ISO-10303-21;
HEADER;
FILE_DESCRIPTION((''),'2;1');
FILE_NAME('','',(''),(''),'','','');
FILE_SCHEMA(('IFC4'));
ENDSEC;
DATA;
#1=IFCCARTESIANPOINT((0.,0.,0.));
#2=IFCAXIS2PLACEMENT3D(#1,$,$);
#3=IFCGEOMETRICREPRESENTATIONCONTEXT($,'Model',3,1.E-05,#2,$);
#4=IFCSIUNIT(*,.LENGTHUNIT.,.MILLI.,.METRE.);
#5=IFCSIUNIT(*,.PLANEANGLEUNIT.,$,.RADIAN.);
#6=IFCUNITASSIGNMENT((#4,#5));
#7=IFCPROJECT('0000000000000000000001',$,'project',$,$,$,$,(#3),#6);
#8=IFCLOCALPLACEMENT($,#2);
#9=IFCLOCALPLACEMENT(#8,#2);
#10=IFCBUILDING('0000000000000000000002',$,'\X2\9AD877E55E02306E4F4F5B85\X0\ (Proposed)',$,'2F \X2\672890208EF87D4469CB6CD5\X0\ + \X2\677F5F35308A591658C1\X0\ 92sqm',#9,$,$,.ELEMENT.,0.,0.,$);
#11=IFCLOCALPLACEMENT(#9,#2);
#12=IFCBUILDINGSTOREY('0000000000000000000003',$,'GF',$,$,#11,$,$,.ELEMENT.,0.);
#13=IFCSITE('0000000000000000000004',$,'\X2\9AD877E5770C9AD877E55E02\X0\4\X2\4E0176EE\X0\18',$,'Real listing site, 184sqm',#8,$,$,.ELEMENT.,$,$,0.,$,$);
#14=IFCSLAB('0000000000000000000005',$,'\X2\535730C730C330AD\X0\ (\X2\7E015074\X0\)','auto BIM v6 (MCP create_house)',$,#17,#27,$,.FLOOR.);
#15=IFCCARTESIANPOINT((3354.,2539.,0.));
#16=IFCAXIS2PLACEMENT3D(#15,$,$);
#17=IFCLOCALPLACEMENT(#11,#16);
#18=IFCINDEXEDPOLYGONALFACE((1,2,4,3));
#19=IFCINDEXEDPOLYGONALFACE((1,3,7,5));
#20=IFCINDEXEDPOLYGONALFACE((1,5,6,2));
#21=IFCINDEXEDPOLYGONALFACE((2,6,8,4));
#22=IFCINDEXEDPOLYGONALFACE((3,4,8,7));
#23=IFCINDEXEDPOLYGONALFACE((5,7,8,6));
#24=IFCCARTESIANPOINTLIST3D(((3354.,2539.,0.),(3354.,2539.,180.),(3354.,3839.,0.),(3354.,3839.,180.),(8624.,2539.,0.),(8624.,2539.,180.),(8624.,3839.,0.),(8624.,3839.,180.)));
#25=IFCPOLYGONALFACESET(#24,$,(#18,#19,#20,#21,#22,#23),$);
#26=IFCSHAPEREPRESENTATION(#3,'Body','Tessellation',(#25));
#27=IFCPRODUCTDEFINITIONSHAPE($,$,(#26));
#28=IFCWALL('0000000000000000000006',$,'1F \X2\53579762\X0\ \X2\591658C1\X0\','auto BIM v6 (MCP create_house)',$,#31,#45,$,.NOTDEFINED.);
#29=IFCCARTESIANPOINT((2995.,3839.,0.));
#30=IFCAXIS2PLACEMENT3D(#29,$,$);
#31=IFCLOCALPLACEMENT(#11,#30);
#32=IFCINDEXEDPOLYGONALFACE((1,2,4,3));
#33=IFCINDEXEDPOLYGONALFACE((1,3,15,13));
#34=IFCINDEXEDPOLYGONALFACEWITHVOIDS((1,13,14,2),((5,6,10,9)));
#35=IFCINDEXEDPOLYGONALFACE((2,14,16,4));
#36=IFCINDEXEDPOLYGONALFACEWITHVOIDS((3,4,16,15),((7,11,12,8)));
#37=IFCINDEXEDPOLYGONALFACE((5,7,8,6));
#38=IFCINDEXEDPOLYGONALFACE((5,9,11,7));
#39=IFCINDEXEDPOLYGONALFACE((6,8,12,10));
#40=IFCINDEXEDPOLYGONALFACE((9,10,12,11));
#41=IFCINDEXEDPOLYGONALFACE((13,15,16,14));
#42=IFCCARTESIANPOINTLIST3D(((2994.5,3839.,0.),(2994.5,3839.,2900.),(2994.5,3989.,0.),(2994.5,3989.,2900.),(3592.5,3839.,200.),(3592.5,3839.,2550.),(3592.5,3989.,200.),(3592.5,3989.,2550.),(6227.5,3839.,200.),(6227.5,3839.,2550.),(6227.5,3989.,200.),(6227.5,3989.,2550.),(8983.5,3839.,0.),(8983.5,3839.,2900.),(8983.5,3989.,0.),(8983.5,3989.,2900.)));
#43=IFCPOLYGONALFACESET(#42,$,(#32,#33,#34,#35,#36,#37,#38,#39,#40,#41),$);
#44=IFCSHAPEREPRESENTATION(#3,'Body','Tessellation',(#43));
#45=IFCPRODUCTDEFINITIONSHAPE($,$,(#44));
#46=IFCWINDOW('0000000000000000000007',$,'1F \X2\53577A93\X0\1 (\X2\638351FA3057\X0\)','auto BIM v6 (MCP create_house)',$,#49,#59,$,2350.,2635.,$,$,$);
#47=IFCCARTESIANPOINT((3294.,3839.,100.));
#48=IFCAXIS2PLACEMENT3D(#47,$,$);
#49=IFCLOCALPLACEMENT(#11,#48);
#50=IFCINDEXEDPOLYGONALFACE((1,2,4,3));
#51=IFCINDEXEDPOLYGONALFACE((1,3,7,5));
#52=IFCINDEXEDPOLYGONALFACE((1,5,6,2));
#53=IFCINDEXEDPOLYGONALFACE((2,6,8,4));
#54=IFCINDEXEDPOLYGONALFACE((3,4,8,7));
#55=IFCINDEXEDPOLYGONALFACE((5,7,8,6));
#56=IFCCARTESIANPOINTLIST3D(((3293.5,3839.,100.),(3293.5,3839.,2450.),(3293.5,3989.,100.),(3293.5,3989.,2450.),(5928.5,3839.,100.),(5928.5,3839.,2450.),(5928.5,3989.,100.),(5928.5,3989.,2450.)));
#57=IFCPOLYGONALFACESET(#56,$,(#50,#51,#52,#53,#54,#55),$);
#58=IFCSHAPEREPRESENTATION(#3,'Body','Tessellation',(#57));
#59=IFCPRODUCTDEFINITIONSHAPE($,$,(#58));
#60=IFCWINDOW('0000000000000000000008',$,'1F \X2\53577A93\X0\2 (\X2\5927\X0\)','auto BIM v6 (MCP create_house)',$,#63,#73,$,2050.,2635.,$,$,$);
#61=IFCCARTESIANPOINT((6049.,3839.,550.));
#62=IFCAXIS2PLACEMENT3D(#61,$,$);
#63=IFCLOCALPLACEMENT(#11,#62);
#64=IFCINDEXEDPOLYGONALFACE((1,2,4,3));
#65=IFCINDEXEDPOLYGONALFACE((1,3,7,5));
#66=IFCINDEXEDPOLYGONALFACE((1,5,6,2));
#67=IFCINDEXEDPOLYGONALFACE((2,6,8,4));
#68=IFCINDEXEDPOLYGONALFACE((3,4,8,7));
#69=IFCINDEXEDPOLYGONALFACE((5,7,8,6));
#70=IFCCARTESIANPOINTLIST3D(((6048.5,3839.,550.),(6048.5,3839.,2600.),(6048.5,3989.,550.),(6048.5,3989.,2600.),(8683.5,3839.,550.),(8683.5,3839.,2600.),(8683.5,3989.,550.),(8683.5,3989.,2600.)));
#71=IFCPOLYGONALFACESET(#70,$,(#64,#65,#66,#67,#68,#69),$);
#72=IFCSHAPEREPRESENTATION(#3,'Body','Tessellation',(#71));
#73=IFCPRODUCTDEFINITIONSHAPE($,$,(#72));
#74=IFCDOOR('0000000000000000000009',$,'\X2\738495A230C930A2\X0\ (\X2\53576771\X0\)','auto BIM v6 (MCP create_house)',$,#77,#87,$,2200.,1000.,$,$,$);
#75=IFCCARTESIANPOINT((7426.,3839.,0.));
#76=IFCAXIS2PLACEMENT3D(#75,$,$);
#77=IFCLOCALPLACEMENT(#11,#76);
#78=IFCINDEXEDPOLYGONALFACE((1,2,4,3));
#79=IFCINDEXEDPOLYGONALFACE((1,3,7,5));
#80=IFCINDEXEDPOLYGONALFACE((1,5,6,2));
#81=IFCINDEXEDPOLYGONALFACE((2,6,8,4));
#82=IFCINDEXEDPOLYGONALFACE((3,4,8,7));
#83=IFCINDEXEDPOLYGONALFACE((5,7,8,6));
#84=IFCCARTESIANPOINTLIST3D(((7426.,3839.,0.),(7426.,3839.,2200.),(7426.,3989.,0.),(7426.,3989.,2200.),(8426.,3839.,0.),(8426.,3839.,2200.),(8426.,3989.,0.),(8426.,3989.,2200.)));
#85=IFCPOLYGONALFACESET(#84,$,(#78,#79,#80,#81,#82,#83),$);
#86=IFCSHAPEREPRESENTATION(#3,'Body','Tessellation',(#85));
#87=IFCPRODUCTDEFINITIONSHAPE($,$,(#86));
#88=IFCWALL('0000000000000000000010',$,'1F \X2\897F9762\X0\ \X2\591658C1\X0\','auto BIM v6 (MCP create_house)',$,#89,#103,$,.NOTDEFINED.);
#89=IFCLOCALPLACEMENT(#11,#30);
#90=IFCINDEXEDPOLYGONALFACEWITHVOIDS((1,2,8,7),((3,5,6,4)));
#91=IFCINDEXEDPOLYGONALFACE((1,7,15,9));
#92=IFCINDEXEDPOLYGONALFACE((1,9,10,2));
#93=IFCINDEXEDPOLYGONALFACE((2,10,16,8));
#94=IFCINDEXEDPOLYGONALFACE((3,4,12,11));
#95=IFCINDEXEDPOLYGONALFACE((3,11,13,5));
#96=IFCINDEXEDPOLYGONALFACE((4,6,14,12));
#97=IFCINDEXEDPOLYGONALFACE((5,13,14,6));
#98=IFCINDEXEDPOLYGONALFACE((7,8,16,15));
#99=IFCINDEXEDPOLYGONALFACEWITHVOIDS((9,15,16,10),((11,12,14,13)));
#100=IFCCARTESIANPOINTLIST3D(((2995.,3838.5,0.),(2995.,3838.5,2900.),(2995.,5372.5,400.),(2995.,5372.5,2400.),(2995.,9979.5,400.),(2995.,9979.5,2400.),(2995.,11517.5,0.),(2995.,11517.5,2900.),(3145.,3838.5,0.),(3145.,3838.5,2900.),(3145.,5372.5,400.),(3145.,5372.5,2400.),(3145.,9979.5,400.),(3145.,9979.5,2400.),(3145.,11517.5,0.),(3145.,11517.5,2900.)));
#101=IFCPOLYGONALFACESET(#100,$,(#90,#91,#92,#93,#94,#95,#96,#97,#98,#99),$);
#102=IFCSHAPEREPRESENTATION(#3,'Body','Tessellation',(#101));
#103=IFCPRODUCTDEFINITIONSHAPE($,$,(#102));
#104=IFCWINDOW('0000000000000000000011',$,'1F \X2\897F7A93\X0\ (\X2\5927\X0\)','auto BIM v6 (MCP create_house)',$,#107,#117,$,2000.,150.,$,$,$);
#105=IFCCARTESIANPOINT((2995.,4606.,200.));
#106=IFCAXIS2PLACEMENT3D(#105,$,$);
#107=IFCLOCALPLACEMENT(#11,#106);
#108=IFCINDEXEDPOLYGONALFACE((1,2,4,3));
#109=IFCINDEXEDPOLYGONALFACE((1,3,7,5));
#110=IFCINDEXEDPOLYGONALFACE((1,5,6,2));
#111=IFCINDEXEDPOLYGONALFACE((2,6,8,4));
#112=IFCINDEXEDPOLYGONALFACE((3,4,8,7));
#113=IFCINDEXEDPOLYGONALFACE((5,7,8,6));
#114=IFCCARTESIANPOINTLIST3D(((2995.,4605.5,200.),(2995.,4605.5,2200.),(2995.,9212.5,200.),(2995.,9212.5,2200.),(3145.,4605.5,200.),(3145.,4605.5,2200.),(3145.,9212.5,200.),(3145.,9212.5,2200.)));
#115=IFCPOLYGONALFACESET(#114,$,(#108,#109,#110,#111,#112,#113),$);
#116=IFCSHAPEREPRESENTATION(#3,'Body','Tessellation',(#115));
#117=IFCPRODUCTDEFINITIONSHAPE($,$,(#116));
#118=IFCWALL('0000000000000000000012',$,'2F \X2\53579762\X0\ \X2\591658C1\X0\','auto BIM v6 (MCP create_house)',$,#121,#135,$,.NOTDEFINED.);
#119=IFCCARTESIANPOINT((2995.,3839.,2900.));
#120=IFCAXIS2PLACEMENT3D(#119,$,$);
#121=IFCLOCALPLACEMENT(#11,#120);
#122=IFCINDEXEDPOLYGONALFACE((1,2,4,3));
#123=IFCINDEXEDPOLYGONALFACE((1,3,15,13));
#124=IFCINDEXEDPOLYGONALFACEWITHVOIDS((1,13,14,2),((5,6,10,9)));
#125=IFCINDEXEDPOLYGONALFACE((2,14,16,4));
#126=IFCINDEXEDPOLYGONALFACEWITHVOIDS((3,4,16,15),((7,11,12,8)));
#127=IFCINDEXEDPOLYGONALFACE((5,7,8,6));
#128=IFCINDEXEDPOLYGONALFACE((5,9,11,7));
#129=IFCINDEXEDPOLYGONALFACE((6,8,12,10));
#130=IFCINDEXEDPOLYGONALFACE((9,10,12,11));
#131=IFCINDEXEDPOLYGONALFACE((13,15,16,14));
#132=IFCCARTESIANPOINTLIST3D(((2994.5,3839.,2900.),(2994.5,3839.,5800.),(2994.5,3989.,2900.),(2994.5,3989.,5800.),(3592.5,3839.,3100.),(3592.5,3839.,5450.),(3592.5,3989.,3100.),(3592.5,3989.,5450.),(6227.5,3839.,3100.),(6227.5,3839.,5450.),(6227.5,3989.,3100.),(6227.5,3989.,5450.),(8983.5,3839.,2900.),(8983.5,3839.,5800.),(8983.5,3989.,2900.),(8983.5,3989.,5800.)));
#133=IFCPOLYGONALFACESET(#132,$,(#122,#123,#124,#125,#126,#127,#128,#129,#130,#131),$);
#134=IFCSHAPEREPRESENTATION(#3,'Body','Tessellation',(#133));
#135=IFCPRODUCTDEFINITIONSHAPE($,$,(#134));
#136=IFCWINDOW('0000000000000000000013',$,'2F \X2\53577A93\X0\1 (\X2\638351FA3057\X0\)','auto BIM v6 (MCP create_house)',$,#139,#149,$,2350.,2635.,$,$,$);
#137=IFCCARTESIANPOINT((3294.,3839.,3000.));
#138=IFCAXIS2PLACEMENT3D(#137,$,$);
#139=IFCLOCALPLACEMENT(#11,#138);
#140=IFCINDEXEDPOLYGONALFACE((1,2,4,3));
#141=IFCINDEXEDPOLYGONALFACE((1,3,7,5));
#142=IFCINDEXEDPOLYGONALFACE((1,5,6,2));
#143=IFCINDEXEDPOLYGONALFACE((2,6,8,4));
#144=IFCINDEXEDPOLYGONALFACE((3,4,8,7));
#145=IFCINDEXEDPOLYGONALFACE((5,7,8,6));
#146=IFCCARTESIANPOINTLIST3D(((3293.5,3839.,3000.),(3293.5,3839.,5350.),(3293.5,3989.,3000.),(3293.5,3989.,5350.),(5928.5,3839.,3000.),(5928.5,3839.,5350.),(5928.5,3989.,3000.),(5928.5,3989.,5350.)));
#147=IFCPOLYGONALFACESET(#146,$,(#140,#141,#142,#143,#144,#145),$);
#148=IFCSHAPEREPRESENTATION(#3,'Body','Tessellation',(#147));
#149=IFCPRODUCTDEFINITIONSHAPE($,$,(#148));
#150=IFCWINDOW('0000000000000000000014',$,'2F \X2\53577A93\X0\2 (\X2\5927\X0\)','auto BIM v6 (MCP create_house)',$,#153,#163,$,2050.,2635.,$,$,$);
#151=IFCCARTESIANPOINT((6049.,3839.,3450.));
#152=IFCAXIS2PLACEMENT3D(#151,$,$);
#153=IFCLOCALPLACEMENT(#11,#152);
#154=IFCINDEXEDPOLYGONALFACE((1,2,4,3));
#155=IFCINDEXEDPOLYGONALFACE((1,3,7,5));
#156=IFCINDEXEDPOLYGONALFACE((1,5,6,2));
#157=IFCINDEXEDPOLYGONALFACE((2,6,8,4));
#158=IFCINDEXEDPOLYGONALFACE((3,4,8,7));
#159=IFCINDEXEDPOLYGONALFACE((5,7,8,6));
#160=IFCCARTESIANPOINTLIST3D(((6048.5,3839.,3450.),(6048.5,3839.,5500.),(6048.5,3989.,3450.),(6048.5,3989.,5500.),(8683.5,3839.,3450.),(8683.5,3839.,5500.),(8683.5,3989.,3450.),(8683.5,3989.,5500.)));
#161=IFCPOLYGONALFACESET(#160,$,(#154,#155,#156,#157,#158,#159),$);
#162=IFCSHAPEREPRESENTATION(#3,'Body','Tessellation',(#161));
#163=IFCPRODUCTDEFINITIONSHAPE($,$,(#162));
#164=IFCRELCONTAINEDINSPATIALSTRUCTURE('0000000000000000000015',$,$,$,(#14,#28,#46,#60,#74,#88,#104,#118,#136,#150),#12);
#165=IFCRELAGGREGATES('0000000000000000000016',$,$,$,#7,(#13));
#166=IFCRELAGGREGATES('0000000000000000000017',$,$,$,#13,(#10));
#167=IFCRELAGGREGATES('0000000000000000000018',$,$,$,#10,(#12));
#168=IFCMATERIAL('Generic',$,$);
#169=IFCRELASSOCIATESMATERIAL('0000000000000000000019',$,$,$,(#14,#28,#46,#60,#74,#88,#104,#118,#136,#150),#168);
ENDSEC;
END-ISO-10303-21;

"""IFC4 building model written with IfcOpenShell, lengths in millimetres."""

from ifc_helpers import new_model, si_unit, frame, frame_2d, origin, place, context, project, spatial, rectangle, extrude, material, element, fill, save


model = new_model("IFC4")

# Units and contexts
model_context = context("Model", 3, precision=1e-05, world=origin())
ifc_project = project(units=[si_unit("LENGTHUNIT", "METRE", prefix="MILLI"), si_unit("PLANEANGLEUNIT", "RADIAN")], contexts=[model_context])

# Site, building, storey
site_placement = place(None, origin())
site = spatial("IfcSite", under=ifc_project, at=site_placement, Name="高知県高知市4丁目18", ObjectType="Real listing site, 184sqm", CompositionType="ELEMENT", RefElevation=0.0)
building_placement = place(site_placement, origin())
building = spatial("IfcBuilding", under=site, at=building_placement, Name="高知市の住宅 (Proposed)", ObjectType="2F 木造軸組構法 + 板張り外壁 92sqm", CompositionType="ELEMENT", ElevationOfRefHeight=0.0, ElevationOfTerrain=0.0)
storey_placement = place(building_placement, origin())
storey = spatial("IfcBuildingStorey", under=building, at=storey_placement, Name="GF", CompositionType="ELEMENT", Elevation=0.0)

# Slab
ifc_material = material(Name="Generic")
slab_1_placement = place(storey_placement, frame((3354.0, 2539.0, 0.0)))
element("IfcSlab", 1, at=slab_1_placement, inside=storey, material=ifc_material, Name="南デッキ (縁側)", Description="auto BIM v6 (MCP create_house)", PredefinedType="FLOOR", context=model_context, shape_type="SweptSolid", body=[
    extrude(rectangle(XDim=5270.0, YDim=1300.0, at=frame_2d((2635.0, 650.0))), frame((3354.0, 2539.0, 0.0)), (0.0, 0.0, 1.0), 180.0),
])

# Wall, openings, windows, door
wall_1_placement = place(storey_placement, frame((2995.0, 3839.0, 0.0)))
wall_1 = element("IfcWall", 2, at=wall_1_placement, inside=storey, material=ifc_material, Name="1F 南面 外壁", Description="auto BIM v6 (MCP create_house)", PredefinedType="NOTDEFINED", context=model_context, shape_type="SweptSolid", body=[
    extrude(rectangle(XDim=5989.0, YDim=150.0, at=frame_2d((2994.0, 75.0))), frame((2995.0, 3839.0, 0.0)), (0.0, 0.0, 1.0), 2900.0),
])
opening_1_placement = place(storey_placement, frame((3294.0, 3839.0, 100.0)))
opening_1 = element("IfcOpeningElement", 3, at=opening_1_placement, cuts=wall_1, PredefinedType="NOTDEFINED", context=model_context, shape_type="SweptSolid", body=[
    extrude(rectangle(XDim=2635.0, YDim=150.0, at=frame_2d((1317.0, 75.0))), frame((3294.0, 3839.0, 100.0)), (0.0, 0.0, 1.0), 2350.0),
])
opening_2_placement = place(storey_placement, frame((6049.0, 3839.0, 550.0)))
opening_2 = element("IfcOpeningElement", 4, at=opening_2_placement, cuts=wall_1, PredefinedType="NOTDEFINED", context=model_context, shape_type="SweptSolid", body=[
    extrude(rectangle(XDim=2635.0, YDim=150.0, at=frame_2d((1317.0, 75.0))), frame((6049.0, 3839.0, 550.0)), (0.0, 0.0, 1.0), 2050.0),
])
opening_3_placement = place(storey_placement, frame((7426.0, 3839.0, 0.0)))
opening_3 = element("IfcOpeningElement", 5, at=opening_3_placement, cuts=wall_1, PredefinedType="NOTDEFINED", context=model_context, shape_type="SweptSolid", body=[
    extrude(rectangle(XDim=1000.0, YDim=150.0, at=frame_2d((500.0, 75.0))), frame((7426.0, 3839.0, 0.0)), (0.0, 0.0, 1.0), 2200.0),
])
window_1_placement = place(storey_placement, frame((3294.0, 3839.0, 100.0)))
window_1 = element("IfcWindow", 6, at=window_1_placement, inside=storey, material=ifc_material, Name="1F 南窓1 (掃出し)", Description="auto BIM v6 (MCP create_house)", OverallHeight=2350.0, OverallWidth=2635.0, context=model_context, shape_type="SweptSolid", body=[
    extrude(rectangle(XDim=2635.0, YDim=150.0, at=frame_2d((1317.0, 75.0))), frame((3294.0, 3839.0, 100.0)), (0.0, 0.0, 1.0), 2350.0),
])
fill(opening_1, window_1)
window_2_placement = place(storey_placement, frame((6049.0, 3839.0, 550.0)))
window_2 = element("IfcWindow", 7, at=window_2_placement, inside=storey, material=ifc_material, Name="1F 南窓2 (大)", Description="auto BIM v6 (MCP create_house)", OverallHeight=2050.0, OverallWidth=2635.0, context=model_context, shape_type="SweptSolid", body=[
    extrude(rectangle(XDim=2635.0, YDim=150.0, at=frame_2d((1317.0, 75.0))), frame((6049.0, 3839.0, 550.0)), (0.0, 0.0, 1.0), 2050.0),
])
fill(opening_2, window_2)
door_placement = place(storey_placement, frame((7426.0, 3839.0, 0.0)))
door = element("IfcDoor", 8, at=door_placement, inside=storey, material=ifc_material, Name="玄関ドア (南東)", Description="auto BIM v6 (MCP create_house)", OverallHeight=2200.0, OverallWidth=1000.0, context=model_context, shape_type="SweptSolid", body=[
    extrude(rectangle(XDim=1000.0, YDim=150.0, at=frame_2d((500.0, 75.0))), frame((7426.0, 3839.0, 0.0)), (0.0, 0.0, 1.0), 2200.0),
])
fill(opening_3, door)

# Wall, opening, window
wall_2_placement = place(storey_placement, frame((2995.0, 3839.0, 0.0)))
wall_2 = element("IfcWall", 9, at=wall_2_placement, inside=storey, material=ifc_material, Name="1F 西面 外壁", Description="auto BIM v6 (MCP create_house)", PredefinedType="NOTDEFINED", context=model_context, shape_type="SweptSolid", body=[
    extrude(rectangle(XDim=150.0, YDim=7679.0, at=frame_2d((75.0, 3839.0))), frame((2995.0, 3839.0, 0.0)), (0.0, 0.0, 1.0), 2900.0),
])
opening_4_placement = place(storey_placement, frame((2995.0, 4606.0, 200.0)))
opening_4 = element("IfcOpeningElement", 10, at=opening_4_placement, cuts=wall_2, PredefinedType="NOTDEFINED", context=model_context, shape_type="SweptSolid", body=[
    extrude(rectangle(XDim=150.0, YDim=4607.0, at=frame_2d((75.0, 2303.0))), frame((2995.0, 4606.0, 200.0)), (0.0, 0.0, 1.0), 2000.0),
])
window_3_placement = place(storey_placement, frame((2995.0, 4606.0, 200.0)))
window_3 = element("IfcWindow", 11, at=window_3_placement, inside=storey, material=ifc_material, Name="1F 西窓 (大)", Description="auto BIM v6 (MCP create_house)", OverallHeight=2000.0, OverallWidth=150.0, context=model_context, shape_type="SweptSolid", body=[
    extrude(rectangle(XDim=150.0, YDim=4607.0, at=frame_2d((75.0, 2303.0))), frame((2995.0, 4606.0, 200.0)), (0.0, 0.0, 1.0), 2000.0),
])
fill(opening_4, window_3)

# Wall, openings, windows
wall_3_placement = place(storey_placement, frame((2995.0, 3839.0, 2900.0)))
wall_3 = element("IfcWall", 12, at=wall_3_placement, inside=storey, material=ifc_material, Name="2F 南面 外壁", Description="auto BIM v6 (MCP create_house)", PredefinedType="NOTDEFINED", context=model_context, shape_type="SweptSolid", body=[
    extrude(rectangle(XDim=5989.0, YDim=150.0, at=frame_2d((2994.0, 75.0))), frame((2995.0, 3839.0, 2900.0)), (0.0, 0.0, 1.0), 2900.0),
])
opening_5_placement = place(storey_placement, frame((3294.0, 3839.0, 3000.0)))
opening_5 = element("IfcOpeningElement", 13, at=opening_5_placement, cuts=wall_3, PredefinedType="NOTDEFINED", context=model_context, shape_type="SweptSolid", body=[
    extrude(rectangle(XDim=2635.0, YDim=150.0, at=frame_2d((1317.0, 75.0))), frame((3294.0, 3839.0, 3000.0)), (0.0, 0.0, 1.0), 2350.0),
])
opening_6_placement = place(storey_placement, frame((6049.0, 3839.0, 3450.0)))
opening_6 = element("IfcOpeningElement", 14, at=opening_6_placement, cuts=wall_3, PredefinedType="NOTDEFINED", context=model_context, shape_type="SweptSolid", body=[
    extrude(rectangle(XDim=2635.0, YDim=150.0, at=frame_2d((1317.0, 75.0))), frame((6049.0, 3839.0, 3450.0)), (0.0, 0.0, 1.0), 2050.0),
])
window_4_placement = place(storey_placement, frame((3294.0, 3839.0, 3000.0)))
window_4 = element("IfcWindow", 15, at=window_4_placement, inside=storey, material=ifc_material, Name="2F 南窓1 (掃出し)", Description="auto BIM v6 (MCP create_house)", OverallHeight=2350.0, OverallWidth=2635.0, context=model_context, shape_type="SweptSolid", body=[
    extrude(rectangle(XDim=2635.0, YDim=150.0, at=frame_2d((1317.0, 75.0))), frame((3294.0, 3839.0, 3000.0)), (0.0, 0.0, 1.0), 2350.0),
])
fill(opening_5, window_4)
window_5_placement = place(storey_placement, frame((6049.0, 3839.0, 3450.0)))
window_5 = element("IfcWindow", 16, at=window_5_placement, inside=storey, material=ifc_material, Name="2F 南窓2 (大)", Description="auto BIM v6 (MCP create_house)", OverallHeight=2050.0, OverallWidth=2635.0, context=model_context, shape_type="SweptSolid", body=[
    extrude(rectangle(XDim=2635.0, YDim=150.0, at=frame_2d((1317.0, 75.0))), frame((6049.0, 3839.0, 3450.0)), (0.0, 0.0, 1.0), 2050.0),
])
fill(opening_6, window_5)

save(model, "model.ifc")
